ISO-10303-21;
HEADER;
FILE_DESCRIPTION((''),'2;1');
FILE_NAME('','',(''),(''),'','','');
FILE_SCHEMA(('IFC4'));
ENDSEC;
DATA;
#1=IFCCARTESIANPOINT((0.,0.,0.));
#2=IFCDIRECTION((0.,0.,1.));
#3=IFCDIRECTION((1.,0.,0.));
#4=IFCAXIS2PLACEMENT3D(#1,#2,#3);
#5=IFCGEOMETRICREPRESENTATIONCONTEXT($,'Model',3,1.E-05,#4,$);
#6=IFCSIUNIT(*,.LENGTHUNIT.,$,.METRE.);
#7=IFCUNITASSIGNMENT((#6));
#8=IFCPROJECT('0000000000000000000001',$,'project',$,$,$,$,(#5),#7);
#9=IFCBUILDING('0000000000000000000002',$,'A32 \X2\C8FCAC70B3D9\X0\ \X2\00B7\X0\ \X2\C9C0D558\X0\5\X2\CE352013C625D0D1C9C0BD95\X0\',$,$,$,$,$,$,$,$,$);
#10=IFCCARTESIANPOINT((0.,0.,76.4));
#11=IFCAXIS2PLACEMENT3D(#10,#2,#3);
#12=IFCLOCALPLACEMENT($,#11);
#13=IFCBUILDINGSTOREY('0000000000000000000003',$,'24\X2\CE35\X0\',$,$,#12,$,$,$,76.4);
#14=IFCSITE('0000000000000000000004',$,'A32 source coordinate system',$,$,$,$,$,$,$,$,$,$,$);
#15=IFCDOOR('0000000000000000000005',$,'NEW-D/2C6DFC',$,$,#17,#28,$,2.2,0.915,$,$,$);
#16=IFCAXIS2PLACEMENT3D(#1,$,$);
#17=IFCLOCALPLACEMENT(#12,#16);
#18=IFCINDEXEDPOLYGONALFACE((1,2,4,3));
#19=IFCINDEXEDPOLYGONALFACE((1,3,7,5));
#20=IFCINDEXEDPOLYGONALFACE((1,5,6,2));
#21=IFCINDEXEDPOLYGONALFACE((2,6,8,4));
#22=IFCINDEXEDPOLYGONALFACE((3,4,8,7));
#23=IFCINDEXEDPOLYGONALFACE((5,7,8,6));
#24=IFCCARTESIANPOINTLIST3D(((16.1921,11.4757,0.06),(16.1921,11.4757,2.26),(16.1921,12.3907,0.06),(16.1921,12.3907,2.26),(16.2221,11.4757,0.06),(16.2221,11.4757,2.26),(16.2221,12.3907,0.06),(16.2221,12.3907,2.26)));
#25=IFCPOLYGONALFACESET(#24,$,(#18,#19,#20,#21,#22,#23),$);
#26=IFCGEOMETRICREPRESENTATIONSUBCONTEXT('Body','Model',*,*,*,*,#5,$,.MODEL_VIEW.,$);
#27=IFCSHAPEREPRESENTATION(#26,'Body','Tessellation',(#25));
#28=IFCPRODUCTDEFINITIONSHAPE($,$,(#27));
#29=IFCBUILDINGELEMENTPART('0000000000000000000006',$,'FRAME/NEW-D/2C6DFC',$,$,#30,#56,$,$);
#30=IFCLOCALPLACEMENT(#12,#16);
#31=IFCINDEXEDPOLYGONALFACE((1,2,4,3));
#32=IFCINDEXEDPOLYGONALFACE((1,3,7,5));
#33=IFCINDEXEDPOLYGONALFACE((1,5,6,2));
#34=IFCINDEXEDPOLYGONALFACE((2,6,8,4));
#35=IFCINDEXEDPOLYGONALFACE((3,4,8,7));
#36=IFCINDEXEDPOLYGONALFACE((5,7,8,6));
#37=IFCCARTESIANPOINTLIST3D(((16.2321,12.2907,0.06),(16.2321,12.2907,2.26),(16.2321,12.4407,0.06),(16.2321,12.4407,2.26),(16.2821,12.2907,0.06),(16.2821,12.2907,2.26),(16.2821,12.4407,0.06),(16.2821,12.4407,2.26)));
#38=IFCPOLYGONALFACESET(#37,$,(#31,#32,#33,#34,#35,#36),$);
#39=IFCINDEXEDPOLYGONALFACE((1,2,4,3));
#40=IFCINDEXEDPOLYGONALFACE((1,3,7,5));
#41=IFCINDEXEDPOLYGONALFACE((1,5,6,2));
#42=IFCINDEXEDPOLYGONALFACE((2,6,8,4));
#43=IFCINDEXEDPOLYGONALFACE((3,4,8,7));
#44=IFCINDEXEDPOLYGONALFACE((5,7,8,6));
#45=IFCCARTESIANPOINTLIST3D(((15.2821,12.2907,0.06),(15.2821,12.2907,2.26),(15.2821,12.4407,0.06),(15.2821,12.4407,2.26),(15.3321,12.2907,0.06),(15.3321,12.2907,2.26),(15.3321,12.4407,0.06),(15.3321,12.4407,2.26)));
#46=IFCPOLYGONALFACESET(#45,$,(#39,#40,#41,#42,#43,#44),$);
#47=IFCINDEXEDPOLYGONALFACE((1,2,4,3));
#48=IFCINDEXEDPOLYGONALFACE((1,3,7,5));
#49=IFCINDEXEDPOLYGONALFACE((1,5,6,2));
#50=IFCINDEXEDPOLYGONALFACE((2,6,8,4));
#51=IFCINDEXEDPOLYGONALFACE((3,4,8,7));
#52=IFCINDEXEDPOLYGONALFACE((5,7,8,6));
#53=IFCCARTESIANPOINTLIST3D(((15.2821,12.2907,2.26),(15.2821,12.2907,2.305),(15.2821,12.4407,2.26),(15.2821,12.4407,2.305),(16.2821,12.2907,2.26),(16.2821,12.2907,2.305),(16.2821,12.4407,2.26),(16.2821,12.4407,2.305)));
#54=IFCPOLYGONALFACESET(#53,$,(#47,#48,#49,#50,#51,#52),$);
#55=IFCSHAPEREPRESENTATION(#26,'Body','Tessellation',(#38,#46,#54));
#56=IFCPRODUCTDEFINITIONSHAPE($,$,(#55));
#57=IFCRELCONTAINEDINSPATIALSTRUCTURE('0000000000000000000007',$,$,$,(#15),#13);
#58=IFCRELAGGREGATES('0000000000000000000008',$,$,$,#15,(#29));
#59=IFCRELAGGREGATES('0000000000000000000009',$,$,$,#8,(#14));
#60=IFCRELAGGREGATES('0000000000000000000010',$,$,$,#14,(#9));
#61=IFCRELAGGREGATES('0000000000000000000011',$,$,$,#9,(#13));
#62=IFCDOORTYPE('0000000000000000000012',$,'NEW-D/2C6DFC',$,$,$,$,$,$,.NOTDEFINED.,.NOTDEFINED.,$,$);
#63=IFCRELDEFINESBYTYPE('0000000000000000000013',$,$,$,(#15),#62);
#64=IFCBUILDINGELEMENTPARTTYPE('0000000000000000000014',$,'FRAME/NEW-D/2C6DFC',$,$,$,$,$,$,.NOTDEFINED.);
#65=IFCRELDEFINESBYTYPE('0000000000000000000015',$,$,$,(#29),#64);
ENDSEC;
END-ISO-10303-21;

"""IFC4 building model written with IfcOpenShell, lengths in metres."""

from ifc_helpers import new_model, si_unit, frame, origin, origin_with_axes, place, context, subcontext, project, spatial, polyline, outline, extrude, source, transform, mapped, type_object, type_shapes, element, aggregate, save


model = new_model("IFC4")

# Units and contexts
model_context = context("Model", 3, precision=1e-05, world=origin_with_axes())
body_context = subcontext(model_context, "Body", "Model", "MODEL_VIEW")
ifc_project = project(units=[si_unit("LENGTHUNIT", "METRE")], contexts=[model_context])

# Site, building, storey
site = spatial("IfcSite", under=ifc_project, Name="A32 source coordinate system")
building = spatial("IfcBuilding", under=site, Name="A32 주거동 · 지하5층–옥탑지붕")
storey_placement = place(None, frame((0.0, 0.0, 76.4), z_axis=(0.0, 0.0, 1.0), x_axis=(1.0, 0.0, 0.0)))
storey = spatial("IfcBuildingStorey", under=building, at=storey_placement, Name="24층", Elevation=76.4)

# Door
door_type_1 = type_object("IfcDoorType", Name="NEW-D/2C6DFC", OperationType="NOTDEFINED", PredefinedType="NOTDEFINED")
shared_shape_1 = source(origin(), body_context, "Body", "SweptSolid", [
    extrude(outline(polyline([(16.2221, 11.4757), (16.1921, 11.4757), (16.1921, 12.3907), (16.2221, 12.3907), (16.2221, 11.4757)])), frame((0.0, 0.0, 0.06)), (0.0, 0.0, 1.0), 2.2),
])
type_shapes(door_type_1, [shared_shape_1])
door_1_placement = place(storey_placement, origin_with_axes())
door_1 = element("IfcDoor", 1, at=door_1_placement, inside=storey, type_object=door_type_1, Name="NEW-D/2C6DFC", OverallHeight=2.2, OverallWidth=0.915, context=body_context, shape_type="MappedRepresentation", body=[
    mapped(shared_shape_1, transform((0.0, 0.0, 0.0), scale=1.0)),
])

# Building element part
building_element_part_type_1 = type_object("IfcBuildingElementPartType", Name="FRAME/NEW-D/2C6DFC", PredefinedType="NOTDEFINED")
shared_shape_2 = source(origin(), body_context, "Body", "SweptSolid", [
    extrude(outline(polyline([(16.2321, 12.4407), (16.2821, 12.4407), (16.2821, 12.2907), (16.2321, 12.2907), (16.2321, 12.4407)])), frame((0.0, 0.0, 0.06)), (0.0, 0.0, 1.0), 2.2),
    extrude(outline(polyline([(15.2821, 12.4407), (15.3321, 12.4407), (15.3321, 12.2907), (15.2821, 12.2907), (15.2821, 12.4407)])), frame((0.0, 0.0, 0.06)), (0.0, 0.0, 1.0), 2.2),
    extrude(outline(polyline([(16.2821, 12.2907), (16.2821, 12.4407), (15.2821, 12.4407), (15.2821, 12.2907), (16.2821, 12.2907)])), frame((0.0, 0.0, 2.26)), (0.0, 0.0, 1.0), 0.045),
])
type_shapes(building_element_part_type_1, [shared_shape_2])
building_element_part_1_placement = place(door_1_placement, origin_with_axes())
building_element_part_1 = element("IfcBuildingElementPart", 2, at=building_element_part_1_placement, type_object=building_element_part_type_1, Name="FRAME/NEW-D/2C6DFC", context=body_context, shape_type="MappedRepresentation", body=[
    mapped(shared_shape_2, transform((0.0, 0.0, 0.0), scale=1.0)),
])
aggregate(door_1, [building_element_part_1])

save(model, "model.ifc")
